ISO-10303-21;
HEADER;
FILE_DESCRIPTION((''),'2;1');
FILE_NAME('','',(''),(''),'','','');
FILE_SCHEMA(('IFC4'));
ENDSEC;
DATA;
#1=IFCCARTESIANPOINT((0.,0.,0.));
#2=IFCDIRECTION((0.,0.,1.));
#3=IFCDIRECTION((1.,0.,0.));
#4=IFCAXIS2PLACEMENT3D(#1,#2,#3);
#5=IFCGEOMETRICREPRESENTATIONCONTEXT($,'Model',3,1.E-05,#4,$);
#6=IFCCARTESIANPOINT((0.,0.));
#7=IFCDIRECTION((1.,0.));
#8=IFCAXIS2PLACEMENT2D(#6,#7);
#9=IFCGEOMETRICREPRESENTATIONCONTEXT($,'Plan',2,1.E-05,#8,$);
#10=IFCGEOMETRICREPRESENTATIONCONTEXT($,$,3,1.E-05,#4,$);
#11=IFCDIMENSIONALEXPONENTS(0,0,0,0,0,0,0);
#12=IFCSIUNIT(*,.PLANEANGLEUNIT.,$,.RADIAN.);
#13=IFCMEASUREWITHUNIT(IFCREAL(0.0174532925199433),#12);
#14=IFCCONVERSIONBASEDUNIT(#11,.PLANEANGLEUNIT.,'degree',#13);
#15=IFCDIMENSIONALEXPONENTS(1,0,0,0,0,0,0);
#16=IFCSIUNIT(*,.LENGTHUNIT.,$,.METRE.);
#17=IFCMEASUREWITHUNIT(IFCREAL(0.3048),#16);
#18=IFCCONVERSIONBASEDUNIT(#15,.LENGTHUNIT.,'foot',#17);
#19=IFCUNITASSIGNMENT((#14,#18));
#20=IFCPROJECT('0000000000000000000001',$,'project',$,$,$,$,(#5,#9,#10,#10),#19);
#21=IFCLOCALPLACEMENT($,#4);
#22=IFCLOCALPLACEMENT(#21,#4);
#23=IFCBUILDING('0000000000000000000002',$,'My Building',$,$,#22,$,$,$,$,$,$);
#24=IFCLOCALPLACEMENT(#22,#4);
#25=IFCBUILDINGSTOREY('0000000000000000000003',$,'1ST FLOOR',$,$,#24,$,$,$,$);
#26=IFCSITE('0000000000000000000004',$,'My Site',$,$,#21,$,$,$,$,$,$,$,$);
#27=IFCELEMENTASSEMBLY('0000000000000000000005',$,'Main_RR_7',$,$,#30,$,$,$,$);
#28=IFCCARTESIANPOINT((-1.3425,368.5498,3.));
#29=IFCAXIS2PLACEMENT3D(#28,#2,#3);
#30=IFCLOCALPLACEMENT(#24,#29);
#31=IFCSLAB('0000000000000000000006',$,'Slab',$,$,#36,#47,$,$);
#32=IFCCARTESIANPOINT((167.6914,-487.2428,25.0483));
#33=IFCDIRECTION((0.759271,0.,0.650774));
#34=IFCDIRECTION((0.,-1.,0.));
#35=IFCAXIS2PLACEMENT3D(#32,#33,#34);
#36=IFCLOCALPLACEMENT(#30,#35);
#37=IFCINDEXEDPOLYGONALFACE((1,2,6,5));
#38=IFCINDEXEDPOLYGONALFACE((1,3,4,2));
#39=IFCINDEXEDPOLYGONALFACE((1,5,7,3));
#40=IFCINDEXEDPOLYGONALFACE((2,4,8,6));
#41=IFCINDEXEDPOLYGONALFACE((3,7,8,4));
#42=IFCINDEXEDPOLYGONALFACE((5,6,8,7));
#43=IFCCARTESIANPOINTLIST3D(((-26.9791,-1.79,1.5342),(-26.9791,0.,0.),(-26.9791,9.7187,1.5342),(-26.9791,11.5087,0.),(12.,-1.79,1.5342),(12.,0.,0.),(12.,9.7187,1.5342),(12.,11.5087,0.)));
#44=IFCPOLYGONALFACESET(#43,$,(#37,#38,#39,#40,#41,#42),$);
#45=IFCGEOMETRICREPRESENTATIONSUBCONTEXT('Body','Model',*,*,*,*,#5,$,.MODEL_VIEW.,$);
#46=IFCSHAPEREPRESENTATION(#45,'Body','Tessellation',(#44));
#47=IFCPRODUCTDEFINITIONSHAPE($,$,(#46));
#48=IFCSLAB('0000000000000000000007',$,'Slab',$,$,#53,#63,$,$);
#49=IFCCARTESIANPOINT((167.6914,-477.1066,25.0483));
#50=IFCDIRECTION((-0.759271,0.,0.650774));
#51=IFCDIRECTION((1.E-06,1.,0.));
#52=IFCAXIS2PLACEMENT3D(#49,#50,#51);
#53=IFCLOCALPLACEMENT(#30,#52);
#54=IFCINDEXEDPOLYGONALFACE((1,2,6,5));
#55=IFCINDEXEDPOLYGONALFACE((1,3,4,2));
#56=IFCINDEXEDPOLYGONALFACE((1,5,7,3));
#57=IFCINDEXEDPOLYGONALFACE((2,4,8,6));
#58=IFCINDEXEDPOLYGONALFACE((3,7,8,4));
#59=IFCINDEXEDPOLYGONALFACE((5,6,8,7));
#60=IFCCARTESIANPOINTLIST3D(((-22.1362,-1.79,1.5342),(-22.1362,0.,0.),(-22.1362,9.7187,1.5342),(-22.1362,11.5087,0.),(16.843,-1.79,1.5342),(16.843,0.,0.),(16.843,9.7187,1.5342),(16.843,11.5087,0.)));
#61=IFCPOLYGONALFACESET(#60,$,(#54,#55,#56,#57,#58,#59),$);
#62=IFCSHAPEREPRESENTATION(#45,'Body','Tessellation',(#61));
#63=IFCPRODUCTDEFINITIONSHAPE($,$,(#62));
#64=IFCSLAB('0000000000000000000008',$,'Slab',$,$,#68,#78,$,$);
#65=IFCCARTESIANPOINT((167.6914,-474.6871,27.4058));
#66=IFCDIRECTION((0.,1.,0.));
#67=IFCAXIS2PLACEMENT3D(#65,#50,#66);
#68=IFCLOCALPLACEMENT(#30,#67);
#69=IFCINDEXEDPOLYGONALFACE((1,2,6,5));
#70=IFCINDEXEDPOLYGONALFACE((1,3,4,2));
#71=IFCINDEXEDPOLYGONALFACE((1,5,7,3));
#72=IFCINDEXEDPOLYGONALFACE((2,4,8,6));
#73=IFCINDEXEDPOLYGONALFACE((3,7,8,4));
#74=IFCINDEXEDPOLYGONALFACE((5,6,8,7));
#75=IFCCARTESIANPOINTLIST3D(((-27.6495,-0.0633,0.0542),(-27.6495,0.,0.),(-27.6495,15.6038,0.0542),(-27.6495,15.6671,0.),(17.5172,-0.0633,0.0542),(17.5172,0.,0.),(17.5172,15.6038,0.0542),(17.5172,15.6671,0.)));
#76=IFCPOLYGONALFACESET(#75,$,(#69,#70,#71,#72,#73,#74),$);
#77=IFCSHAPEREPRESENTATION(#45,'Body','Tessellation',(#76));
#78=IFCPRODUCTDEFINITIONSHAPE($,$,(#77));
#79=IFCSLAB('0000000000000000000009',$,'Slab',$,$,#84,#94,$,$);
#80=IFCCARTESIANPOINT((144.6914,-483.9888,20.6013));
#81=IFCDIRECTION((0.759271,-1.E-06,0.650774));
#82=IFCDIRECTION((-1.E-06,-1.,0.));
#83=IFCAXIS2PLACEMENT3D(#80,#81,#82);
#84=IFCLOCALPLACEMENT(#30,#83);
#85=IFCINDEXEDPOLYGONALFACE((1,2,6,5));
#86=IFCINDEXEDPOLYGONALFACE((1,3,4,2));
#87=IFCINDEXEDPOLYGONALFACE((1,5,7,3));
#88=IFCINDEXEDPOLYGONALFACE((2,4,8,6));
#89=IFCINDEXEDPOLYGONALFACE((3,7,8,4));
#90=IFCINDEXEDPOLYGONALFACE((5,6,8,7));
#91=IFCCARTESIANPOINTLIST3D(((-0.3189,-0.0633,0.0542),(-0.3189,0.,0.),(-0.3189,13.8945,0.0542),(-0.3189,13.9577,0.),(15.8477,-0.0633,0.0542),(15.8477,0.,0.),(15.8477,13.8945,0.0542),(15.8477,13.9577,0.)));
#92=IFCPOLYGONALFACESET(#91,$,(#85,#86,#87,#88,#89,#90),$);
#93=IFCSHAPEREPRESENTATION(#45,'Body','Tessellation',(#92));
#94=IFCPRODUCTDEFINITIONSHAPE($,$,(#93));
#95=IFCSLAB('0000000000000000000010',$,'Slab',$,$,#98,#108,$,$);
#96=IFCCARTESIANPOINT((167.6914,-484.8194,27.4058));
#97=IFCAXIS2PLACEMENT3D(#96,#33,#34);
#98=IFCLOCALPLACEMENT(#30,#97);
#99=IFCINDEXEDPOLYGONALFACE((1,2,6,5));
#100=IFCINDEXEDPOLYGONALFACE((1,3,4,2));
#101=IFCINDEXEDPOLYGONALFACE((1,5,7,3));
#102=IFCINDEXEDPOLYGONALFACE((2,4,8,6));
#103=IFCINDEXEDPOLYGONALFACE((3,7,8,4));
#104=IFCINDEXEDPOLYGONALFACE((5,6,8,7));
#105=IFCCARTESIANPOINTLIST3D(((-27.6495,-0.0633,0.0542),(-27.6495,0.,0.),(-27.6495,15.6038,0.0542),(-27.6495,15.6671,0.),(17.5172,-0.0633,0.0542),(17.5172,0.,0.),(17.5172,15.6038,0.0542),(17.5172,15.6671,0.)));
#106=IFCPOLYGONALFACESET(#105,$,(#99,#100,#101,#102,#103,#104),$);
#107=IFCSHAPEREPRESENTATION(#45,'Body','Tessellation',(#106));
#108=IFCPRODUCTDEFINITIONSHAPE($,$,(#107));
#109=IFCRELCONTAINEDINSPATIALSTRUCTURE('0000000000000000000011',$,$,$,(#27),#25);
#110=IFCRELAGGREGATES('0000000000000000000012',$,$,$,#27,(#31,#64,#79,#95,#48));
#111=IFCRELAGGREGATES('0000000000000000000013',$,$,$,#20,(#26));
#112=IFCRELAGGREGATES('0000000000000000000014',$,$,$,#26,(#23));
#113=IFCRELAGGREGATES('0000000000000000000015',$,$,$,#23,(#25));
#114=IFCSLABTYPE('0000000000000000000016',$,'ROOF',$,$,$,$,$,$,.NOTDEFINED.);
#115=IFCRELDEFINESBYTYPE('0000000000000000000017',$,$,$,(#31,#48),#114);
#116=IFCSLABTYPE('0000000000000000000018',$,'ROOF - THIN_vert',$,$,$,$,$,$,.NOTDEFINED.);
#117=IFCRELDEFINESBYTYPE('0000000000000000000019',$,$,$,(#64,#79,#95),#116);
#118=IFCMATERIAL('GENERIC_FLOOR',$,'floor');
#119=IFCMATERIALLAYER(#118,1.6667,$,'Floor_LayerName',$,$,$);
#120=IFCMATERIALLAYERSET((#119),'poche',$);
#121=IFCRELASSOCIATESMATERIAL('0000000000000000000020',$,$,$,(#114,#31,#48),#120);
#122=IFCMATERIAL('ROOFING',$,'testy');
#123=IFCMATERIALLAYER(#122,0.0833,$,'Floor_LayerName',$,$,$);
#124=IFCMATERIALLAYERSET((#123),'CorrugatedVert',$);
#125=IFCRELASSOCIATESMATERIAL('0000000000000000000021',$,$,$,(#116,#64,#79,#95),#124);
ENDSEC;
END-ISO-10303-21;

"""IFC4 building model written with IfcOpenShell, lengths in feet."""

from ifc_helpers import new_model, entity, si_unit, converted_unit, frame, origin_with_axes, origin_2d_with_axis, place, context, subcontext, project, spatial, line, indexed_curve, outline, extrude, material, layer, layer_set, layer_usage, type_object, element, aggregate, save


model = new_model("IFC4")

# Units and contexts
model_context = context("Model", 3, precision=1e-05, world=origin_with_axes())
plan_context = context("Plan", 2, precision=1e-05, world=origin_2d_with_axis())
context_of_model = context(None, 3, precision=1e-05, world=origin_with_axes())
body_context = subcontext(model_context, "Body", "Model", "MODEL_VIEW")
ifc_project = project(units=[converted_unit("PLANEANGLEUNIT", "degree", entity("IfcReal", 0.0174532925199433), si_unit("PLANEANGLEUNIT", "RADIAN"), dimensions=[0, 0, 0, 0, 0, 0, 0]), converted_unit("LENGTHUNIT", "foot", entity("IfcReal", 0.3048), si_unit("LENGTHUNIT", "METRE"), dimensions=[1, 0, 0, 0, 0, 0, 0])], contexts=[model_context, plan_context, context_of_model, context_of_model])

# Site, building, storey
site_placement = place(None, origin_with_axes())
site = spatial("IfcSite", under=ifc_project, at=site_placement, Name="My Site")
building_placement = place(site_placement, origin_with_axes())
building = spatial("IfcBuilding", under=site, at=building_placement, Name="My Building")
storey_placement = place(building_placement, origin_with_axes())
storey = spatial("IfcBuildingStorey", under=building, at=storey_placement, Name="1ST FLOOR")

# Element assembly, slabs
assembly_placement = place(storey_placement, frame((-1.3425, 368.5498, 3.0), z_axis=(0.0, 0.0, 1.0), x_axis=(1.0, 0.0, 0.0)))
assembly = element("IfcElementAssembly", 1, at=assembly_placement, inside=storey, Name="Main_RR_7")
ifc_material_1 = material(Name="GENERIC_FLOOR", Category="floor")
ifc_layer_1 = layer(ifc_material_1, 1.6667, Name="Floor_LayerName")
ifc_layer_set_1 = layer_set([ifc_layer_1], Name="poche")
ifc_layer_usage_1 = layer_usage(ifc_layer_set_1, "AXIS3", "POSITIVE", 0.0)
slab_type_1 = type_object("IfcSlabType", Name="ROOF", PredefinedType="NOTDEFINED", material=ifc_layer_set_1)
slab_1_placement = place(assembly_placement, frame((167.6914, -487.2428, 25.0483), z_axis=(0.759271, 0.0, 0.650774), x_axis=(0.0, -1.0, 0.0)))
slab_1 = element("IfcSlab", 2, at=slab_1_placement, type_object=slab_type_1, material=ifc_layer_usage_1, Name="Slab", context=body_context, shape_type="SweptSolid", body=[
    extrude(outline(indexed_curve([(-26.9791, 11.5087), (-26.9791, 0.0), (12.0, 0.0), (12.0, 11.5087)], segments=[line(3, 2), line(2, 1), line(1, 4), line(4, 3)], self_intersect=False)), None, (0.0, -0.759271, 0.650774), 2.3575),
])
ifc_layer_usage_2 = layer_usage(ifc_layer_set_1, "AXIS3", "POSITIVE", 0.0)
slab_2_placement = place(assembly_placement, frame((167.6914, -477.1066, 25.0483), z_axis=(-0.759271, 0.0, 0.650774), x_axis=(0.000001, 1.0, 0.0)))
slab_2 = element("IfcSlab", 3, at=slab_2_placement, type_object=slab_type_1, material=ifc_layer_usage_2, Name="Slab", context=body_context, shape_type="SweptSolid", body=[
    extrude(outline(indexed_curve([(-22.1362, 0.0), (-22.1362, 11.5087), (16.843, 11.5087), (16.843, 0.0)], segments=[line(3, 2), line(2, 1), line(1, 4), line(4, 3)], self_intersect=False)), None, (0.0, -0.759271, 0.650774), 2.3575),
])
ifc_material_2 = material(Name="ROOFING", Category="testy")
ifc_layer_2 = layer(ifc_material_2, 0.0833, Name="Floor_LayerName")
ifc_layer_set_2 = layer_set([ifc_layer_2], Name="CorrugatedVert")
ifc_layer_usage_3 = layer_usage(ifc_layer_set_2, "AXIS3", "POSITIVE", 0.0)
slab_type_2 = type_object("IfcSlabType", Name="ROOF - THIN_vert", PredefinedType="NOTDEFINED", material=ifc_layer_set_2)
slab_3_placement = place(assembly_placement, frame((167.6914, -474.6871, 27.4058), z_axis=(-0.759271, 0.0, 0.650774), x_axis=(0.0, 1.0, 0.0)))
slab_3 = element("IfcSlab", 4, at=slab_3_placement, type_object=slab_type_2, material=ifc_layer_usage_3, Name="Slab", context=body_context, shape_type="SweptSolid", body=[
    extrude(outline(indexed_curve([(17.5172, 15.6671), (-27.6495, 15.6671), (-27.6495, 0.0), (17.5172, 0.0)], segments=[line(4, 1), line(1, 2), line(2, 3), line(3, 4)], self_intersect=False)), None, (0.0, -0.759271, 0.650774), 0.0833),
])
ifc_layer_usage_4 = layer_usage(ifc_layer_set_2, "AXIS3", "POSITIVE", 0.0)
slab_4_placement = place(assembly_placement, frame((144.6914, -483.9888, 20.6013), z_axis=(0.759271, -0.000001, 0.650774), x_axis=(-0.000001, -1.0, 0.0)))
slab_4 = element("IfcSlab", 5, at=slab_4_placement, type_object=slab_type_2, material=ifc_layer_usage_4, Name="Slab", context=body_context, shape_type="SweptSolid", body=[
    extrude(outline(indexed_curve([(15.8477, 13.9577), (15.8477, 0.0), (-0.3189, 0.0), (-0.3189, 13.9577)], segments=[line(4, 1), line(1, 2), line(2, 3), line(3, 4)], self_intersect=False)), None, (0.0, -0.759271, 0.650774), 0.0833),
])
ifc_layer_usage_5 = layer_usage(ifc_layer_set_2, "AXIS3", "POSITIVE", 0.0)
slab_5_placement = place(assembly_placement, frame((167.6914, -484.8194, 27.4058), z_axis=(0.759271, 0.0, 0.650774), x_axis=(0.0, -1.0, 0.0)))
slab_5 = element("IfcSlab", 6, at=slab_5_placement, type_object=slab_type_2, material=ifc_layer_usage_5, Name="Slab", context=body_context, shape_type="SweptSolid", body=[
    extrude(outline(indexed_curve([(17.5172, 15.6671), (-27.6495, 15.6671), (-27.6495, 0.0), (17.5172, 0.0)], segments=[line(4, 1), line(1, 2), line(2, 3), line(3, 4)], self_intersect=False)), None, (0.0, -0.759271, 0.650774), 0.0833),
])
aggregate(assembly, [slab_1, slab_3, slab_4, slab_5, slab_2])

save(model, "model.ifc")
